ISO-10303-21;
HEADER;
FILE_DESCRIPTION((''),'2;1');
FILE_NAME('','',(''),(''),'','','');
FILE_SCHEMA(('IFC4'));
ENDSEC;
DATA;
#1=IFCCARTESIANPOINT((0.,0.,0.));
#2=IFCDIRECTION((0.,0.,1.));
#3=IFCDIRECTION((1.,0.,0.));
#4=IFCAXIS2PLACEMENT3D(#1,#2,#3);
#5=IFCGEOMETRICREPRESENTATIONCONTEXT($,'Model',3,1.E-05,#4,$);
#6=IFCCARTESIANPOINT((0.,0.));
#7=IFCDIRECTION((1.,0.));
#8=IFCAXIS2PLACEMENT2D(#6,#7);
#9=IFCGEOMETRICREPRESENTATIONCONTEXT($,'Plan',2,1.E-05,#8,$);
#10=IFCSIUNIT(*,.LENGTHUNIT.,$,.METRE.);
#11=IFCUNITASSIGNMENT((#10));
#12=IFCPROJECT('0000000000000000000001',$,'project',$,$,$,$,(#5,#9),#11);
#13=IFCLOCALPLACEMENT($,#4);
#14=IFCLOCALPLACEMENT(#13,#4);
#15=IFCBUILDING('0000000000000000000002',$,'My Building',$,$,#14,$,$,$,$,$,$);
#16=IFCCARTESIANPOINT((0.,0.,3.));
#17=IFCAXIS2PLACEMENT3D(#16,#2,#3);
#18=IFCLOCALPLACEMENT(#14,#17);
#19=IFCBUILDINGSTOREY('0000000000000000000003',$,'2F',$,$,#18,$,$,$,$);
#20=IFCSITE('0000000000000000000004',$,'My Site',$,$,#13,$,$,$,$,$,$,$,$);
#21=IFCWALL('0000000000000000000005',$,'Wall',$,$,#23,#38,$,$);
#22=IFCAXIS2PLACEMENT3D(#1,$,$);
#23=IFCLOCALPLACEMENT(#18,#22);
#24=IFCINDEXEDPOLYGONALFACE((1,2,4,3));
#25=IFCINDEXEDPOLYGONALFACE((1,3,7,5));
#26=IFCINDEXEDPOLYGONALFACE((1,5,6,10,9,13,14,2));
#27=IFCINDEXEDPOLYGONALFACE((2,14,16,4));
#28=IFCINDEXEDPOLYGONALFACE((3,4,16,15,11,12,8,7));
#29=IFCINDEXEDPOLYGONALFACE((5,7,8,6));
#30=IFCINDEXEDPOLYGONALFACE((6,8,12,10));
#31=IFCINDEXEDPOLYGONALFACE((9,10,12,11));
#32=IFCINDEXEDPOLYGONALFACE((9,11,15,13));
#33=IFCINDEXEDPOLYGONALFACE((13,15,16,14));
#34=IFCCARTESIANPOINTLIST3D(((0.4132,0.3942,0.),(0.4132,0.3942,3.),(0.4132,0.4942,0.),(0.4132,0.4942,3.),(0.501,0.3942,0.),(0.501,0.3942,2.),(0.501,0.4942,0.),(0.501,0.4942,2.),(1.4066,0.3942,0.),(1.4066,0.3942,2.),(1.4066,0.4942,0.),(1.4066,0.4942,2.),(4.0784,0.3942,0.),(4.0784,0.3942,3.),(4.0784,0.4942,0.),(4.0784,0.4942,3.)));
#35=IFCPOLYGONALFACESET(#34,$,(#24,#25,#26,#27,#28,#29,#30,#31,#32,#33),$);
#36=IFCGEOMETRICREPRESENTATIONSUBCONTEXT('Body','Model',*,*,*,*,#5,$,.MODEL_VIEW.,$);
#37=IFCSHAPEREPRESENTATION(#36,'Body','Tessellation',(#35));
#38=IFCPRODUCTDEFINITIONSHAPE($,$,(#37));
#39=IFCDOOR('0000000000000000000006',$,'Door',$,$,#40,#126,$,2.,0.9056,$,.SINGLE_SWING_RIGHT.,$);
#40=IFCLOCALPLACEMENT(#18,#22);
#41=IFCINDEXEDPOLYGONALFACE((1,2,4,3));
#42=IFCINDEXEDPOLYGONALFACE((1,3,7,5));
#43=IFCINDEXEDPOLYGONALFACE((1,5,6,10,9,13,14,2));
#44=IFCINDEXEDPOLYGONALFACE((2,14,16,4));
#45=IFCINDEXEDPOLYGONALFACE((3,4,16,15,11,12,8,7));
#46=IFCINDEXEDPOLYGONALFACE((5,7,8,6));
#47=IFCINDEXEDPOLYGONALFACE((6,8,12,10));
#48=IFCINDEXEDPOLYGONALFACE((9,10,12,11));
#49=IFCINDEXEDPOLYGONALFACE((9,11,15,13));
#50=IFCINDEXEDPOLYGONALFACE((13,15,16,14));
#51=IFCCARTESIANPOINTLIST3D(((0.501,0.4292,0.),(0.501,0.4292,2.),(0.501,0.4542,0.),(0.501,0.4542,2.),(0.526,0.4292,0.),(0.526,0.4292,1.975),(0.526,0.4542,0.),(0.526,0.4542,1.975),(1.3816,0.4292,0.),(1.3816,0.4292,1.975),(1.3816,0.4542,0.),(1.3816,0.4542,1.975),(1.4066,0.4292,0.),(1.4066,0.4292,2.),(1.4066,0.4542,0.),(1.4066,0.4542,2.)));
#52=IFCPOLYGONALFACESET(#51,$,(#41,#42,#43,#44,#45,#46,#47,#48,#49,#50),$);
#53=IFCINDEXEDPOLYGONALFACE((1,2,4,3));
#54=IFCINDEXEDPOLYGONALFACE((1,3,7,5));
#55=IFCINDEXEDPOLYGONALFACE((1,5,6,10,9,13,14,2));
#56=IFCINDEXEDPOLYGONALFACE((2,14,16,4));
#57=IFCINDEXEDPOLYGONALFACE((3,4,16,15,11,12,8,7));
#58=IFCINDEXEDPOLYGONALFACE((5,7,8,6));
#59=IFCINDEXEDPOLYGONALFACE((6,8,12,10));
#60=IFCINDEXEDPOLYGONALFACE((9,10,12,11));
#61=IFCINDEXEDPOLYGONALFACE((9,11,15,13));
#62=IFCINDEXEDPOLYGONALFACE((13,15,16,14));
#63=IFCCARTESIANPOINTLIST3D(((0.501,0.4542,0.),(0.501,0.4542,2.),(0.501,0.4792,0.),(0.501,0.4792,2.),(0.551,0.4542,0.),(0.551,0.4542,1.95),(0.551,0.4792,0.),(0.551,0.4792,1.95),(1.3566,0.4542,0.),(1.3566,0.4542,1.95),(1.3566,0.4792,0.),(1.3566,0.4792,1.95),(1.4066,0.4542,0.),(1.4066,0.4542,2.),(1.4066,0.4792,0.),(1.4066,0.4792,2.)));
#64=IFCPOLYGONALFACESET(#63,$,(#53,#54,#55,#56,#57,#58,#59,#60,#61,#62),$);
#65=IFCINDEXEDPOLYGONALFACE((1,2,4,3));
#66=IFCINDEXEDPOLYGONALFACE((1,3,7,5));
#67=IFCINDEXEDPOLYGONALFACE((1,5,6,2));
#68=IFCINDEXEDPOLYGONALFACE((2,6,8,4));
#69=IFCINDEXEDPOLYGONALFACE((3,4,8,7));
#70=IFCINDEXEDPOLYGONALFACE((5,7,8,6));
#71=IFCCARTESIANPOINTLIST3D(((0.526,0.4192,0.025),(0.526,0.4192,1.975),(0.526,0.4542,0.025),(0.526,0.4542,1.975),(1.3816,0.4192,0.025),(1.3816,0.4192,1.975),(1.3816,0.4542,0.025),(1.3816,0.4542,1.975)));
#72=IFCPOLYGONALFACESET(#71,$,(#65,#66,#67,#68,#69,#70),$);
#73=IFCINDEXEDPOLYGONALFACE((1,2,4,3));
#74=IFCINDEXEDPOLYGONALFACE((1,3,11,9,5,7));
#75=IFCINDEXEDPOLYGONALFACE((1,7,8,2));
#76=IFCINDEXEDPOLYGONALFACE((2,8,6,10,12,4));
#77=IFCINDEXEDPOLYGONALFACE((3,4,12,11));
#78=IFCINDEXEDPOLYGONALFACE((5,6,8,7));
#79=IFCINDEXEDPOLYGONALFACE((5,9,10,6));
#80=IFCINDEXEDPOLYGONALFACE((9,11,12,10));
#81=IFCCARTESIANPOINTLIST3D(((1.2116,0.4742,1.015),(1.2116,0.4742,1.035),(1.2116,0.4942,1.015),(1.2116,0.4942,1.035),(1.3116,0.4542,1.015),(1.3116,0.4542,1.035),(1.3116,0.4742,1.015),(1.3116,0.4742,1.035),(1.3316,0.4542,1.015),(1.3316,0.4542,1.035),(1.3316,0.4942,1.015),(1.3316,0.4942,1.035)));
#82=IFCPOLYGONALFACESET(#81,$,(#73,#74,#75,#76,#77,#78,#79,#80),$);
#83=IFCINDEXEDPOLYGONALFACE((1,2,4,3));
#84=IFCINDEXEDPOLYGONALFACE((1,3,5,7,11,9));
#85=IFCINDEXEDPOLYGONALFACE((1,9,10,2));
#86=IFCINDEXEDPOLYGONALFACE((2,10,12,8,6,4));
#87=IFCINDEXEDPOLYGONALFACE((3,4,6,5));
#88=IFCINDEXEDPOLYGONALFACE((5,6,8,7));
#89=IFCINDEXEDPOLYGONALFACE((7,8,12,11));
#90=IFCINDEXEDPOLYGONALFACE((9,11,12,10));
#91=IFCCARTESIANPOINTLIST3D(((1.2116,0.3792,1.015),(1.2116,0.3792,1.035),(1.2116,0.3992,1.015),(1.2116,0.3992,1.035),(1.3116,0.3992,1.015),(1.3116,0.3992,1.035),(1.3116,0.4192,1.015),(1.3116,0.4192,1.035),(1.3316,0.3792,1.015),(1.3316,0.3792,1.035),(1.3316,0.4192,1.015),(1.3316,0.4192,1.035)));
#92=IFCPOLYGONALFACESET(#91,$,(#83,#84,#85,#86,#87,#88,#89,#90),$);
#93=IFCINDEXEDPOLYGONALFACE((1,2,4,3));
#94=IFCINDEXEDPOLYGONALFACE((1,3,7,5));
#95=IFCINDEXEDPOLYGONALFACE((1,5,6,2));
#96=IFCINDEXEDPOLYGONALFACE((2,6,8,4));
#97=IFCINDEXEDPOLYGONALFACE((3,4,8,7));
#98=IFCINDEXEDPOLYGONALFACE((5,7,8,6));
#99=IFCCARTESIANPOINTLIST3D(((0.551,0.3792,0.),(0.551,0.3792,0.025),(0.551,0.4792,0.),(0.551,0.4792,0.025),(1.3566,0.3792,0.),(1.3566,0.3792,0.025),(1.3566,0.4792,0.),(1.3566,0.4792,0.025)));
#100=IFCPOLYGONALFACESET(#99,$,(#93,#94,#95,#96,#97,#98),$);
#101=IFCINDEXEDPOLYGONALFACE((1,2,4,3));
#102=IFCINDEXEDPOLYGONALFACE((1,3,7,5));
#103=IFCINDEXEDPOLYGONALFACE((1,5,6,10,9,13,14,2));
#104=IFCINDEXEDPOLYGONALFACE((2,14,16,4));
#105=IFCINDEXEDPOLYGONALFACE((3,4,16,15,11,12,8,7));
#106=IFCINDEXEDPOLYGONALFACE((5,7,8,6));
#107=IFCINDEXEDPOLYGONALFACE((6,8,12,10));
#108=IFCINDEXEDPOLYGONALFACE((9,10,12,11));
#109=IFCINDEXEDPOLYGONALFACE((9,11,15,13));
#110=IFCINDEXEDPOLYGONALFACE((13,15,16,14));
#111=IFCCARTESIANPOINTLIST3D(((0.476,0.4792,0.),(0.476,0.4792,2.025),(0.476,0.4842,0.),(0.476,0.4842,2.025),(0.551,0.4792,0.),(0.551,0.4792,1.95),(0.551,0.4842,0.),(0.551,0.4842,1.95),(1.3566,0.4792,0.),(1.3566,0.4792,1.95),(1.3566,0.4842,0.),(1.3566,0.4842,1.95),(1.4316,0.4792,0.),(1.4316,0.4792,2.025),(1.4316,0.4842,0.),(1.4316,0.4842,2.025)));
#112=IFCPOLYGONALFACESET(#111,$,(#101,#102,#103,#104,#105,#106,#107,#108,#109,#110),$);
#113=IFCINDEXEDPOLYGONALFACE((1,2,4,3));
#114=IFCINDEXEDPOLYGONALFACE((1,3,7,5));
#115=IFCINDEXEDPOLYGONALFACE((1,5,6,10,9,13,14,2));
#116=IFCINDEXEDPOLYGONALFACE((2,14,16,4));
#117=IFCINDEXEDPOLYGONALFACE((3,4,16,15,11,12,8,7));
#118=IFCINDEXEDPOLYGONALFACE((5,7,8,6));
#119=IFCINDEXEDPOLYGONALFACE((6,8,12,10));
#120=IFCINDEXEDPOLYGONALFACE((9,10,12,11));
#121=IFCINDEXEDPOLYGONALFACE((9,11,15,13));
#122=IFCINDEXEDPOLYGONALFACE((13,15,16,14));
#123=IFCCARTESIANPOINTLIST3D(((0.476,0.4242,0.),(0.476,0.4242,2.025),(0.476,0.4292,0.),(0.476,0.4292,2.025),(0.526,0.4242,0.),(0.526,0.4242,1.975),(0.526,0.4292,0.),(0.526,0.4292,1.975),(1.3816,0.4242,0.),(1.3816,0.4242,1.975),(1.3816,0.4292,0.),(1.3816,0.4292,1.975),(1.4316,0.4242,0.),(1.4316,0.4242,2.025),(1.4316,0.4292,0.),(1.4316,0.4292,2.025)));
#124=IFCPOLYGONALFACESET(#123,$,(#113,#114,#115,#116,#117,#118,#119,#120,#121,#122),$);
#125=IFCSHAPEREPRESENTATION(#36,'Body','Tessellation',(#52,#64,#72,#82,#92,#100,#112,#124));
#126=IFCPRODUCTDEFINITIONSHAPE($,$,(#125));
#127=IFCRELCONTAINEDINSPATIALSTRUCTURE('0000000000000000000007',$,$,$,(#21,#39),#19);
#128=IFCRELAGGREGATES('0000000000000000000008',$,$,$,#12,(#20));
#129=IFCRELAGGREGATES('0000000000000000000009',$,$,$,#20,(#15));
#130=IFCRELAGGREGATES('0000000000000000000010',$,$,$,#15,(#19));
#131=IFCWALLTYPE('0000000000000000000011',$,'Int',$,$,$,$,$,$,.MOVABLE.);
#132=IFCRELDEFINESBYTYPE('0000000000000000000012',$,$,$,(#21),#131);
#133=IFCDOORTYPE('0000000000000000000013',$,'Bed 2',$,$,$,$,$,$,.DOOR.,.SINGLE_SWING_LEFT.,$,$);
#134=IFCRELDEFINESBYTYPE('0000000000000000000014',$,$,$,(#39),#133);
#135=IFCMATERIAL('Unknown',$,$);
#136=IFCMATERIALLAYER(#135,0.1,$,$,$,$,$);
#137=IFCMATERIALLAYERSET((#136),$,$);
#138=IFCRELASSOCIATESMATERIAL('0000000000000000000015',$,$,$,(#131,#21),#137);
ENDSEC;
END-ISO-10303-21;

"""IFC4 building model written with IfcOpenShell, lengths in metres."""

from ifc_helpers import new_model, entity, si_unit, frame, origin_with_axes, origin_2d_with_axis, place, context, subcontext, project, spatial, line, indexed_curve, outline, extrude, shape, source, transform, mapped, material, layer, layer_set, layer_usage, type_object, type_shapes, element, fill, save


model = new_model("IFC4")

# Units and contexts
model_context = context("Model", 3, precision=1e-05, world=origin_with_axes())
plan_context = context("Plan", 2, precision=1e-05, world=origin_2d_with_axis())
body_context_1 = subcontext(model_context, "Body", "Model", "MODEL_VIEW")
body_context_2 = subcontext(plan_context, "Body", "Plan", "PLAN_VIEW")
ifc_project = project(units=[si_unit("LENGTHUNIT", "METRE")], contexts=[model_context, plan_context])

# Site, building, storey
site_placement = place(None, origin_with_axes())
site = spatial("IfcSite", under=ifc_project, at=site_placement, Name="My Site")
building_placement = place(site_placement, origin_with_axes())
building = spatial("IfcBuilding", under=site, at=building_placement, Name="My Building")
storey_placement = place(building_placement, frame((0.0, 0.0, 3.0), z_axis=(0.0, 0.0, 1.0), x_axis=(1.0, 0.0, 0.0)))
storey = spatial("IfcBuildingStorey", under=building, at=storey_placement, Name="2F")

# Shared definitions
ifc_material = material(Name="Unknown")

# Wall, opening, door
ifc_layer_1 = layer(ifc_material, 0.1)
ifc_layer_set_1 = layer_set([ifc_layer_1])
ifc_layer_usage_1 = layer_usage(ifc_layer_set_1, "AXIS2", "POSITIVE", 0.0)
wall_type_1 = type_object("IfcWallType", Name="Int", PredefinedType="MOVABLE", material=ifc_layer_set_1)
wall_1_placement = place(storey_placement, frame((0.4132, 0.3942, 0.0), z_axis=(0.0, 0.0, 1.0), x_axis=(1.0, 0.0, 0.0)))
wall_1 = element("IfcWall", 1, at=wall_1_placement, inside=storey, type_object=wall_type_1, material=ifc_layer_usage_1, Name="Wall", context=body_context_1, shape_type="SweptSolid", body=[
    extrude(outline(indexed_curve([(0.0, 0.0), (0.0, 0.1), (3.6652, 0.1), (3.6652, 0.0)], segments=[line(1, 2, 3, 4, 1)])), origin_with_axes(), (0.0, 0.0, 1.0), 3.0),
])
shared_shape_1 = source(origin_with_axes(), body_context_1, "Body", "SweptSolid", [
    extrude(outline(indexed_curve([(0.0, 0.0), (0.9056, 0.0), (0.9056, 2.0), (0.0, 2.0)], segments=[line(1, 2, 3, 4, 1)])), frame((0.0, -0.6, 0.0), z_axis=(0.0, -1.0, 0.0), x_axis=(1.0, 0.0, 0.0)), (0.0, 0.0, -1.0), 1.2),
])
opening_1_placement = place(wall_1_placement, frame((0.9934, 0.085, 0.0), z_axis=(0.0, 0.0, 1.0), x_axis=(-1.0, 0.0, 0.0)))
opening_1 = element("IfcOpeningElement", 2, at=opening_1_placement, cuts=wall_1, PredefinedType="OPENING", context=body_context_1, shape_type="MappedRepresentation", body=[
    mapped(shared_shape_1, transform((0.0, 0.0, 0.0), x_axis=(1.0, 0.0, 0.0), y_axis=(0.0, 1.0, 0.0), z_axis=(0.0, 0.0, 1.0), scale=1.0)),
])
door_type_1 = type_object("IfcDoorType", Name="Bed 2", OperationType="SINGLE_SWING_LEFT", PredefinedType="DOOR")
shared_shape_2 = source(origin_with_axes(), body_context_1, "Body", "SweptSolid", [
    extrude(outline(indexed_curve([(0.0, 0.0), (0.0, 2.0), (0.9056, 2.0), (0.9056, 0.0), (0.8806, 0.0), (0.8806, 1.975), (0.025, 1.975), (0.025, 0.0), (0.0, 0.0)])), frame((0.0, 0.025, 0.0), z_axis=(0.0, -1.0, 0.0), x_axis=(1.0, 0.0, 0.0)), (0.0, 0.0, -1.0), 0.025),
    extrude(outline(indexed_curve([(0.0, 0.0), (0.0, 2.0), (0.9056, 2.0), (0.9056, 0.0), (0.8556, 0.0), (0.8556, 1.95), (0.05, 1.95), (0.05, 0.0)], segments=[line(1, 2, 3, 4, 5, 6, 7, 8, 1)])), frame((0.0, 0.0, 0.0), z_axis=(0.0, -1.0, 0.0), x_axis=(1.0, 0.0, 0.0)), (0.0, 0.0, -1.0), 0.025),
    extrude(outline(indexed_curve([(0.0, 0.0), (0.8556, 0.0), (0.8556, 0.035), (0.0, 0.035)], segments=[line(1, 2, 3, 4, 1)])), frame((0.025, 0.025, 0.025), z_axis=(0.0, 0.0, 1.0), x_axis=(1.0, 0.0, 0.0)), (0.0, 0.0, 1.0), 1.95),
    extrude(outline(indexed_curve([(0.0, 0.0), (0.0, -0.04), (0.12, -0.04), (0.12, -0.02), (0.02, -0.02), (0.02, 0.0)], segments=[line(1, 2, 3, 4, 5, 6, 1)])), frame((0.075, 0.025, 1.015), z_axis=(0.0, 0.0, 1.0), x_axis=(1.0, 0.0, 0.0)), (0.0, 0.0, 1.0), 0.02),
    extrude(outline(indexed_curve([(0.0, 0.0), (0.0, 0.04), (0.12, 0.04), (0.12, 0.02), (0.02, 0.02), (0.02, 0.0)], segments=[line(1, 2, 3, 4, 5, 6, 1)])), frame((0.075, 0.06, 1.015), z_axis=(0.0, 0.0, 1.0), x_axis=(1.0, 0.0, 0.0)), (0.0, 0.0, 1.0), 0.02),
    extrude(outline(indexed_curve([(0.0, 0.0), (0.8056, 0.0), (0.8056, 0.1), (0.0, 0.1)], segments=[line(1, 2, 3, 4, 1)])), frame((0.05, 0.0, 0.0), z_axis=(0.0, 0.0, 1.0), x_axis=(1.0, 0.0, 0.0)), (0.0, 0.0, 1.0), 0.025),
    extrude(outline(indexed_curve([(0.0, 0.0), (0.0, 2.025), (0.9556, 2.025), (0.9556, 0.0), (0.8806, 0.0), (0.8806, 1.95), (0.075, 1.95), (0.075, 0.0)], segments=[line(1, 2, 3, 4, 5, 6, 7, 8, 1)])), frame((-0.025, -0.005, 0.0), z_axis=(0.0, -1.0, 0.0), x_axis=(1.0, 0.0, 0.0)), (0.0, 0.0, -1.0), 0.005),
    extrude(outline(indexed_curve([(0.0, 0.0), (0.0, 2.025), (0.9556, 2.025), (0.9556, 0.0), (0.9056, 0.0), (0.9056, 1.975), (0.05, 1.975), (0.05, 0.0)], segments=[line(1, 2, 3, 4, 5, 6, 7, 8, 1)])), frame((-0.025, 0.05, 0.0), z_axis=(0.0, -1.0, 0.0), x_axis=(1.0, 0.0, 0.0)), (0.0, 0.0, -1.0), 0.005),
])
shared_shape_3 = source(origin_with_axes(), body_context_2, "Body", "Curve2D", [
    entity("IfcIndexedPolyCurve", entity("IfcCartesianPointList2D", [[0.0, 0.0], [0.0, 0.05], [0.025, 0.05], [0.025, 0.025], [0.05, 0.025], [0.05, 0.0]]), [entity("IfcLineIndex", [1, 2, 3, 4, 5, 6, 1])]),
    entity("IfcIndexedPolyCurve", entity("IfcCartesianPointList2D", [[0.9056, 0.0], [0.9056, 0.05], [0.8806, 0.05], [0.8806, 0.025], [0.8556, 0.025], [0.8556, 0.0]]), [entity("IfcLineIndex", [1, 2, 3, 4, 5, 6, 1])]),
    entity("IfcTrimmedCurve", entity("IfcEllipse", entity("IfcAxis2Placement2D", entity("IfcCartesianPoint", [0.8456, 0.05]), entity("IfcDirection", [1.0, 0.0])), 0.8206, 0.8556), [entity("IfcCartesianPoint", [0.8456, 0.9056])], [entity("IfcCartesianPoint", [0.025, 0.05])], True, "CARTESIAN"),
    entity("IfcIndexedPolyCurve", entity("IfcCartesianPointList2D", [[0.8806, 0.05], [0.8456, 0.05], [0.8456, 0.9056], [0.8806, 0.9056]]), [entity("IfcLineIndex", [1, 2, 3, 4, 1])]),
])
type_shapes(door_type_1, [shared_shape_2, shared_shape_3])
door_1_placement = place(opening_1_placement, origin_with_axes())
door_1 = element("IfcDoor", 3, at=door_1_placement, inside=storey, type_object=door_type_1, Name="Door", OperationType="SINGLE_SWING_RIGHT", OverallHeight=2.0, OverallWidth=0.9056, shapes=[
    shape(body_context_1, "Body", "MappedRepresentation", [mapped(shared_shape_2, transform((0.0, 0.0, 0.0), x_axis=(1.0, 0.0, 0.0), y_axis=(0.0, 1.0, 0.0), z_axis=(0.0, 0.0, 1.0), scale=1.0))]),
    shape(body_context_2, "Body", "MappedRepresentation", [mapped(shared_shape_3, transform((0.0, 0.0, 0.0), x_axis=(1.0, 0.0, 0.0), y_axis=(0.0, 1.0, 0.0), z_axis=(0.0, 0.0, 1.0), scale=1.0))]),
])
fill(opening_1, door_1)

save(model, "model.ifc")
